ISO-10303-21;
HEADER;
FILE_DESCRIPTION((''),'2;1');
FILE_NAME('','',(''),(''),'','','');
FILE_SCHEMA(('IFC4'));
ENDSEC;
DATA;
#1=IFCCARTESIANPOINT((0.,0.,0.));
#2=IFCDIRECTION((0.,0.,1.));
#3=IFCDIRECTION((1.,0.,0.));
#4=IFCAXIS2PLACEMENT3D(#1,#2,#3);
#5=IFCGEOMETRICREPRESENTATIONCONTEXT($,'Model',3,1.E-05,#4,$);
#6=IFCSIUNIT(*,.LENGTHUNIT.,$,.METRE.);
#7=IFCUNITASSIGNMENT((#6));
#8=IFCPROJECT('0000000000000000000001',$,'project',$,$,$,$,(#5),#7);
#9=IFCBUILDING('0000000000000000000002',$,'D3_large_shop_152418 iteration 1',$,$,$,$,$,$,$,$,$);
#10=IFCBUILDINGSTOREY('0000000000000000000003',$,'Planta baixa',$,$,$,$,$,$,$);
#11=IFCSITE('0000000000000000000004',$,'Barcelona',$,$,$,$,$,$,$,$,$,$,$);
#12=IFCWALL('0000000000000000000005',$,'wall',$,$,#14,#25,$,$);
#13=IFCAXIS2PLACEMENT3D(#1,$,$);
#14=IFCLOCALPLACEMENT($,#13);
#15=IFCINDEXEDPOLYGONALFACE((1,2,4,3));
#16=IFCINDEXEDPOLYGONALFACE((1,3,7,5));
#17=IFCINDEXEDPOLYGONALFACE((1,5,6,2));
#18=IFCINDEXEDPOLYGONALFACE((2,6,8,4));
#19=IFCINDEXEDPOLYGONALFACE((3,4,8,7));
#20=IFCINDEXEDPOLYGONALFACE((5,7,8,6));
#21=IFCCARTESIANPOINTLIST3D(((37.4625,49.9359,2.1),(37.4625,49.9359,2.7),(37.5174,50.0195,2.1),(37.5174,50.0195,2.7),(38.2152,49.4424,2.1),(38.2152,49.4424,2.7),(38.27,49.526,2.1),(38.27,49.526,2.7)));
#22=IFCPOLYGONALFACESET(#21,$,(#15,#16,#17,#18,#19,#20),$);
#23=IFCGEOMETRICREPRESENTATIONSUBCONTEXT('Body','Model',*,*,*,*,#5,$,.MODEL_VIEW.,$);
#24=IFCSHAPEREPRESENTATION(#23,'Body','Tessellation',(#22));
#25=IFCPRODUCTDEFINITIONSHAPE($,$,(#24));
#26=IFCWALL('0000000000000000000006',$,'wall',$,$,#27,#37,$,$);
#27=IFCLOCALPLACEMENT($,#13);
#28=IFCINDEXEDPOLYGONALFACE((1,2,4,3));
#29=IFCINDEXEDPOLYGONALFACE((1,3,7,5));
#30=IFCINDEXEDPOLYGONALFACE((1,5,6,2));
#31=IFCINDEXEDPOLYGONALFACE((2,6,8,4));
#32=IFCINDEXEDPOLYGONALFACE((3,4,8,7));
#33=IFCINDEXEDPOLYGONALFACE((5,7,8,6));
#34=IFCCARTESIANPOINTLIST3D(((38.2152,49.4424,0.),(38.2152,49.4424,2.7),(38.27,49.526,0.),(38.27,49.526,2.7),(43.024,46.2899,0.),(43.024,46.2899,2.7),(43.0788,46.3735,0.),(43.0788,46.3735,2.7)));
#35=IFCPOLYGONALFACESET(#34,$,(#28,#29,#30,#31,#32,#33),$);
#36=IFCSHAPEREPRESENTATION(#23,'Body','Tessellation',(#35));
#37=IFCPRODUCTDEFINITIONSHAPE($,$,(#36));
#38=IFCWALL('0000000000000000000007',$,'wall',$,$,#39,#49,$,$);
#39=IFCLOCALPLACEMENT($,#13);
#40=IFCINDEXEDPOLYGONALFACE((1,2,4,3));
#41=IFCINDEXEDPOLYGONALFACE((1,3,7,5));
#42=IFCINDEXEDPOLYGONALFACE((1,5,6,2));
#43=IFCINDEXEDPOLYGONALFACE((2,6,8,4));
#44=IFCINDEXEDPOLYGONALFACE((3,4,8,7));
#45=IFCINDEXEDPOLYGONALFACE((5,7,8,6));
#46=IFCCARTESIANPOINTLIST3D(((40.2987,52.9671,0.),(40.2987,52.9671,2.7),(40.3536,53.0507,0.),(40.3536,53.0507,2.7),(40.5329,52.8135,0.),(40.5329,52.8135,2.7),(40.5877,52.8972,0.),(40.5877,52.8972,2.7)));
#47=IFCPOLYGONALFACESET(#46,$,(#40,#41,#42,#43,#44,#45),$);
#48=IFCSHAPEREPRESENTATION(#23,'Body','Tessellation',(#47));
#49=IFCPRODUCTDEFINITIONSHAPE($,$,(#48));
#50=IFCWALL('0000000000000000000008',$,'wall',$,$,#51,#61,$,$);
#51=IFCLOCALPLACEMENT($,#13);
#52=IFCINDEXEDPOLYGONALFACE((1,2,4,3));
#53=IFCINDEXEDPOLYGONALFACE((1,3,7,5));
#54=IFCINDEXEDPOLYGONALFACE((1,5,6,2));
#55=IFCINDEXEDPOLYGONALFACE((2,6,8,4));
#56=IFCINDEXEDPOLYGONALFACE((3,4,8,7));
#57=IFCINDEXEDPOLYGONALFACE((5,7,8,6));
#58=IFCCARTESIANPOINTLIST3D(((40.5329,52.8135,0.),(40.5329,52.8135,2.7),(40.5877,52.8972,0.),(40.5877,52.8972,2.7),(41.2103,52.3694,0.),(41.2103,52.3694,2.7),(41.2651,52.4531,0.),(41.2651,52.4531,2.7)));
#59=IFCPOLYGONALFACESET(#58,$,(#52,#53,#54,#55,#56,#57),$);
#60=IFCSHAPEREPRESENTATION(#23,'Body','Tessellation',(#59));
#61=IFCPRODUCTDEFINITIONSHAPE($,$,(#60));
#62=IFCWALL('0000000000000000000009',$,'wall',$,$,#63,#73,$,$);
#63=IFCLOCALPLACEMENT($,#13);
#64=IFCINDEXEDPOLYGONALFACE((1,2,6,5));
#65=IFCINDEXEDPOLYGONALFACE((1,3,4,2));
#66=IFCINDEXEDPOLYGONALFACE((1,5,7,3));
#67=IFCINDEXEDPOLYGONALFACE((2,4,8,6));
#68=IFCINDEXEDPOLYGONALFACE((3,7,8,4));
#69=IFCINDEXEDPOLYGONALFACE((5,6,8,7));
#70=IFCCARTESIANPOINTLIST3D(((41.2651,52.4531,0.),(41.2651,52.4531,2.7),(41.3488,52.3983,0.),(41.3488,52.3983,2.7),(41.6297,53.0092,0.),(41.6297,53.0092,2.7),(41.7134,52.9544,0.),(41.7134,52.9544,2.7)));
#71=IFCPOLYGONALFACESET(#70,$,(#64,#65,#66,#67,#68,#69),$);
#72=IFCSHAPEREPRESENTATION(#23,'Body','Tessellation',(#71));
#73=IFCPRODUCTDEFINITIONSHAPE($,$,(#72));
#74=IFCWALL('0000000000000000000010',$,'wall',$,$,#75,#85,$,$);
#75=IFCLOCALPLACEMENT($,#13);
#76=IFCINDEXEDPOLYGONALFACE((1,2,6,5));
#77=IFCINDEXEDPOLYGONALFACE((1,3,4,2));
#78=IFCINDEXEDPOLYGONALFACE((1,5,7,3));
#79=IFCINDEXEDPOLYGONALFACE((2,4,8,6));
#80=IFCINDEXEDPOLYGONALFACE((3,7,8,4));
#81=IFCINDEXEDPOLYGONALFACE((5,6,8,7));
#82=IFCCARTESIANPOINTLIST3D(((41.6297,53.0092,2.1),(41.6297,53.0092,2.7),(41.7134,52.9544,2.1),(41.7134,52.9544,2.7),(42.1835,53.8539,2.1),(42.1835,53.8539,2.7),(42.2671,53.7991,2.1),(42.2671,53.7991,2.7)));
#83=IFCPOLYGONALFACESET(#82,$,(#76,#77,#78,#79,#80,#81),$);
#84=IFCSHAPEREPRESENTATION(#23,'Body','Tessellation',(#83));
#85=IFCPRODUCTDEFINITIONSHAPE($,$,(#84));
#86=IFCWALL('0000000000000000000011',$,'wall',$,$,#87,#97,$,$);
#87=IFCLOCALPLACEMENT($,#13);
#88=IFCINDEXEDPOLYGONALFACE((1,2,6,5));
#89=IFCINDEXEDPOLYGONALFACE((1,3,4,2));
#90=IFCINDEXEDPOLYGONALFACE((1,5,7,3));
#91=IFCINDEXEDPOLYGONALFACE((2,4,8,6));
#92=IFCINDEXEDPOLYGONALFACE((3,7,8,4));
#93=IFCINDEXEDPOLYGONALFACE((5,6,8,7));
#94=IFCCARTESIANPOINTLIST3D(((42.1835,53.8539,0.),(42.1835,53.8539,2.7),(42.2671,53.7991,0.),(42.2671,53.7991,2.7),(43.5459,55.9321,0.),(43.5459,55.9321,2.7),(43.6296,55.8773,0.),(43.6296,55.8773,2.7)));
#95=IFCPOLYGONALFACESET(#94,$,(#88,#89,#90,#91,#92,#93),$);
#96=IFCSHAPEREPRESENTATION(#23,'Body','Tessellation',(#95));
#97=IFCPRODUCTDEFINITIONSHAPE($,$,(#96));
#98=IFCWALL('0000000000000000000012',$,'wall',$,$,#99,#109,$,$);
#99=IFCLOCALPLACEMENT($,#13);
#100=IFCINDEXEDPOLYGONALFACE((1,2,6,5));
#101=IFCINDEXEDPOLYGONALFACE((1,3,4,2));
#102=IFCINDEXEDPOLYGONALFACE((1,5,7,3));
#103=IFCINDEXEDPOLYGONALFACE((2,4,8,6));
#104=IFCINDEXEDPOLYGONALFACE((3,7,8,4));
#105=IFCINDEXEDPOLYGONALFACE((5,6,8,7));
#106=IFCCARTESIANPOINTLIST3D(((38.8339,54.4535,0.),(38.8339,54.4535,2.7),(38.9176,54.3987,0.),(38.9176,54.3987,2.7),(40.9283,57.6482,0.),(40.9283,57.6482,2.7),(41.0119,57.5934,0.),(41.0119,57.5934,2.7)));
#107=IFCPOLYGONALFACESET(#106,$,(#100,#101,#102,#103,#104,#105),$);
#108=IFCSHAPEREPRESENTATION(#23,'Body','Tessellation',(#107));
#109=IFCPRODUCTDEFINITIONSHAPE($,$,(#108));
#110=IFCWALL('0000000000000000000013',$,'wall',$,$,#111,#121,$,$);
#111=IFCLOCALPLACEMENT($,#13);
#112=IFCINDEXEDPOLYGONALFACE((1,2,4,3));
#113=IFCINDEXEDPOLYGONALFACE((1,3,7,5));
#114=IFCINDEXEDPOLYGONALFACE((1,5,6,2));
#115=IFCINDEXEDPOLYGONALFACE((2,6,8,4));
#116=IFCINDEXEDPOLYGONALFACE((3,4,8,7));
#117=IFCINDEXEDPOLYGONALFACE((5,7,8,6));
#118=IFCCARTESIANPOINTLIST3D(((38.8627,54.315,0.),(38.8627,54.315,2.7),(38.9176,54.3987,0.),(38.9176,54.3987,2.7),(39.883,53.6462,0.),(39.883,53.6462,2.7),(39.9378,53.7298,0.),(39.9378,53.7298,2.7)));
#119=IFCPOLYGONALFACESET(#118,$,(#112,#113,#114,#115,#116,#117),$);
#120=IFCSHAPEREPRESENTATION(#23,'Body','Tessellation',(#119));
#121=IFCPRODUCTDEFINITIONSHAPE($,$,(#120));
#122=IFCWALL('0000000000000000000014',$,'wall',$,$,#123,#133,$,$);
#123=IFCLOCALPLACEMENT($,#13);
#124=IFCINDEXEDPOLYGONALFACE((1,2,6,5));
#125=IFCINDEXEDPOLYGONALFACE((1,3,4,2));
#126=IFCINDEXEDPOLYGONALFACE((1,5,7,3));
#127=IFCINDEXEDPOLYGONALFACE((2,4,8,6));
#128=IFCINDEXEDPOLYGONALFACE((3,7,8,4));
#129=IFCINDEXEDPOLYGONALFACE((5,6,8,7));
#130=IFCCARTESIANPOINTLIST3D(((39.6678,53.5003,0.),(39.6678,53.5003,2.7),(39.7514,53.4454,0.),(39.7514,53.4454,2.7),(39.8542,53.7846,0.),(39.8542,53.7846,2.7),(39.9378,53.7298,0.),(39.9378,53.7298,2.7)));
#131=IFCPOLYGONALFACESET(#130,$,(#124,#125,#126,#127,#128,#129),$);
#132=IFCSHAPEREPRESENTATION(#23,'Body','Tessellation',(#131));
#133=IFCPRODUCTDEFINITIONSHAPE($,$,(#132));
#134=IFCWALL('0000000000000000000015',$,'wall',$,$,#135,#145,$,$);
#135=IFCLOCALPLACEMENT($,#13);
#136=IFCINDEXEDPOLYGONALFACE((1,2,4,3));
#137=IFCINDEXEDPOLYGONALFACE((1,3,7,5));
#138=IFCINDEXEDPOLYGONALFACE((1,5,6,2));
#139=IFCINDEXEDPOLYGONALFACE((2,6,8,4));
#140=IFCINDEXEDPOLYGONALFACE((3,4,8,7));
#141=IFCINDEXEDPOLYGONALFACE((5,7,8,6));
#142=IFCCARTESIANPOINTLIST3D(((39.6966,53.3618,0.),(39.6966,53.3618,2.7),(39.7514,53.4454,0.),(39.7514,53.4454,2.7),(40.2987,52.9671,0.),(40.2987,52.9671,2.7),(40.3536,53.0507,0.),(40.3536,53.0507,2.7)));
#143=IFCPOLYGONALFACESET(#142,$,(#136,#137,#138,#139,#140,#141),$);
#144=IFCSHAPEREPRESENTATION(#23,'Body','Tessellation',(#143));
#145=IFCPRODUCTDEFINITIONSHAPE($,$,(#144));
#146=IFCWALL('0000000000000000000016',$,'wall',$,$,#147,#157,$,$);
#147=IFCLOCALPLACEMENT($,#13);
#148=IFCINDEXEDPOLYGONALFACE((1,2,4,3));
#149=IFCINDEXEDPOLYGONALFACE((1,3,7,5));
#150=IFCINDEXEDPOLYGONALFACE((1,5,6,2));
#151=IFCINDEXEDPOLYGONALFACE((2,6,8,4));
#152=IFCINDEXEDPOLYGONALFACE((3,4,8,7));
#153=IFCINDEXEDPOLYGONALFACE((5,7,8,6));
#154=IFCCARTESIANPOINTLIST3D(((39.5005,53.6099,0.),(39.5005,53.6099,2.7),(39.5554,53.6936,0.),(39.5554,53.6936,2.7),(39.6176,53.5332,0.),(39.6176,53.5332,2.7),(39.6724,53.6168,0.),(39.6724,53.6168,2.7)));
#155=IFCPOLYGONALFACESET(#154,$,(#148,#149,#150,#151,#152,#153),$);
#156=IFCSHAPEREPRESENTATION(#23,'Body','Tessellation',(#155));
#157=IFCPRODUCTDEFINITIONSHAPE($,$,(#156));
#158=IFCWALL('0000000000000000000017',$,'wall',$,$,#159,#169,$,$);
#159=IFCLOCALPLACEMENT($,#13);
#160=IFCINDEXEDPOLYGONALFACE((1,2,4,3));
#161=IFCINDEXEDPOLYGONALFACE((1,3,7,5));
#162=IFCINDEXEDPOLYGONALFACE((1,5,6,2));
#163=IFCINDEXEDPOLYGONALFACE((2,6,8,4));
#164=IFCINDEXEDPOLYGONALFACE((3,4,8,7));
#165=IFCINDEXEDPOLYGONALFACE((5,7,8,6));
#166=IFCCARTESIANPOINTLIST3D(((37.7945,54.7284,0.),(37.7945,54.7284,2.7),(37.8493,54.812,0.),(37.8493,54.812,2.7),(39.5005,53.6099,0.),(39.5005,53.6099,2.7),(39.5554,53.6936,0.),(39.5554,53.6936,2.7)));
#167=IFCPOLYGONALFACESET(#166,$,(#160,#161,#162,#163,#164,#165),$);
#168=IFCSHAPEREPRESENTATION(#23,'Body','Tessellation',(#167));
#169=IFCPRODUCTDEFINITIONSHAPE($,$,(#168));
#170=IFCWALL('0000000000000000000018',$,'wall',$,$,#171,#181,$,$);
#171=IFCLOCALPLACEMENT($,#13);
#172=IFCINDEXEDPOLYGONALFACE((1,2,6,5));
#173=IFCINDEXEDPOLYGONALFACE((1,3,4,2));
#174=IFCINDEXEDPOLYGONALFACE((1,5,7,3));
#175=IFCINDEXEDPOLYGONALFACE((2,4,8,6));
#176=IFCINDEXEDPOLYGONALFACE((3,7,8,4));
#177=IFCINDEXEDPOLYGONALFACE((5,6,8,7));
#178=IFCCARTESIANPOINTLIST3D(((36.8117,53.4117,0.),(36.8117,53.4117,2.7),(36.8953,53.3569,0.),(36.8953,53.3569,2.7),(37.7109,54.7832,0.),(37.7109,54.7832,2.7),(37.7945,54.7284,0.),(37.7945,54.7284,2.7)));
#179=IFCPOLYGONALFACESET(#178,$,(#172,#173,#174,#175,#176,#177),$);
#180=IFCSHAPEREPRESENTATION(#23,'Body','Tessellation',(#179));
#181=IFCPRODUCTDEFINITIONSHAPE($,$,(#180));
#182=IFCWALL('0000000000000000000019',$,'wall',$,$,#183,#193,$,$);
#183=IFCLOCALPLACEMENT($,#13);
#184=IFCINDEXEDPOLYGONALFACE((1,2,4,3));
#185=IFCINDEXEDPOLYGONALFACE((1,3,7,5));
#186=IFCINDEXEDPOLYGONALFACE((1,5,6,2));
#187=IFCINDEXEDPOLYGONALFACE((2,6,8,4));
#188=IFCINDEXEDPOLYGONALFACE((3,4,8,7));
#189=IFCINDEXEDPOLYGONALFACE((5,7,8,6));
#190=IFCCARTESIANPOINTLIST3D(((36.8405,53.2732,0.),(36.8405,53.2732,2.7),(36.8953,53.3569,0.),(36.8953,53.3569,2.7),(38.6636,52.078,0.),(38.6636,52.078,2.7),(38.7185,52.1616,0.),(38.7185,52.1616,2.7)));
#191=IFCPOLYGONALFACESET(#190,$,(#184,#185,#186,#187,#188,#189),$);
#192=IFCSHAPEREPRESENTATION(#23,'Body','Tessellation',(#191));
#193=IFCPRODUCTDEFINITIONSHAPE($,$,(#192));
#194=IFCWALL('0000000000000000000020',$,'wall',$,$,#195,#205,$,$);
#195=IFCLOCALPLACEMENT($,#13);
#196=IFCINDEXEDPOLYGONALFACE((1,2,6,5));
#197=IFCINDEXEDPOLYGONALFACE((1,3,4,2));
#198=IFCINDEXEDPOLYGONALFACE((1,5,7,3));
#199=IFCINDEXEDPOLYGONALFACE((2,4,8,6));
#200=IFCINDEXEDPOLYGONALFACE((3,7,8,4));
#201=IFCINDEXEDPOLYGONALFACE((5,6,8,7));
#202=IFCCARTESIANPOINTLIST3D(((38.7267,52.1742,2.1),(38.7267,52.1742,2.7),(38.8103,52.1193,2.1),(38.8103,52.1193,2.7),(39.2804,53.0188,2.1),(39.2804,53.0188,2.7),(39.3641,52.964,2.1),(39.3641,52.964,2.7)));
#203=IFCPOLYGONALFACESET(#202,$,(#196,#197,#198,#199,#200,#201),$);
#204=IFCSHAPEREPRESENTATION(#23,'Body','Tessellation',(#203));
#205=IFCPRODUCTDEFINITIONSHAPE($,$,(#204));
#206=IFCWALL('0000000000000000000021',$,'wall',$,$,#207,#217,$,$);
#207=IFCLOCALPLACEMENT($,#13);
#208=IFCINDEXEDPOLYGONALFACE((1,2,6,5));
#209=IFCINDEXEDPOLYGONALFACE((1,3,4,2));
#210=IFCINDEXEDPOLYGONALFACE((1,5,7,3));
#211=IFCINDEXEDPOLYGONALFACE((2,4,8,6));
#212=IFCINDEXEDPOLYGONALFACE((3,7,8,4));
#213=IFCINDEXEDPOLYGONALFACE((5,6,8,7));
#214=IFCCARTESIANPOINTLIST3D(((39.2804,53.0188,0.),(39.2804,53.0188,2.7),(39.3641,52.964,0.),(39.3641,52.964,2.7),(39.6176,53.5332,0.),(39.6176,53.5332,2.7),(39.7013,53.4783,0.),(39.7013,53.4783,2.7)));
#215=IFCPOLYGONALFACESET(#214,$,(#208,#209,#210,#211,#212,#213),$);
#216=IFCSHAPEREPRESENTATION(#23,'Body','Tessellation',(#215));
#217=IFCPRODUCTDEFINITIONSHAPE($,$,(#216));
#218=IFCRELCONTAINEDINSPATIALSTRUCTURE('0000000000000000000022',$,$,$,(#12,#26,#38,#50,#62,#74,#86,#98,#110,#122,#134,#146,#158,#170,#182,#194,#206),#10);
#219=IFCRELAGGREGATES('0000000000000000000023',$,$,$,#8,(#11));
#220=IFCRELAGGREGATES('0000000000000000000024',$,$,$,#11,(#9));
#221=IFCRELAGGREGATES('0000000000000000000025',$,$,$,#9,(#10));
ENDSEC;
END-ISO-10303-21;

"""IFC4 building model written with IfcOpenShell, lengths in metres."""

from ifc_helpers import new_model, si_unit, frame, origin, origin_with_axes, place, context, subcontext, project, spatial, polyline, outline, extrude, element, save


model = new_model("IFC4")

# Units and contexts
model_context = context("Model", 3, precision=1e-05, world=origin_with_axes())
body_context = subcontext(model_context, "Body", "Model", "MODEL_VIEW")
ifc_project = project(units=[si_unit("LENGTHUNIT", "METRE")], contexts=[model_context])

# Site, building, storey
site = spatial("IfcSite", under=ifc_project, Name="Barcelona")
building = spatial("IfcBuilding", under=site, Name="D3_large_shop_152418 iteration 1")
storey = spatial("IfcBuildingStorey", under=building, Name="Planta baixa")

# Walls
wall_1_placement = place(None, origin_with_axes())
element("IfcWall", 1, at=wall_1_placement, inside=storey, Name="wall", context=body_context, shape_type="SweptSolid", body=[
    extrude(outline(polyline([(37.5174, 50.0195), (38.27, 49.526), (38.2152, 49.4424), (37.4625, 49.9359), (37.5174, 50.0195)])), frame((0.0, 0.0, 2.1)), (0.0, 0.0, 1.0), 0.6),
])
wall_2_placement = place(None, origin_with_axes())
element("IfcWall", 2, at=wall_2_placement, inside=storey, Name="wall", context=body_context, shape_type="SweptSolid", body=[
    extrude(outline(polyline([(38.27, 49.526), (43.0788, 46.3735), (43.024, 46.2899), (38.2152, 49.4424), (38.27, 49.526)])), origin(), (0.0, 0.0, 1.0), 2.7),
])
wall_3_placement = place(None, origin_with_axes())
element("IfcWall", 3, at=wall_3_placement, inside=storey, Name="wall", context=body_context, shape_type="SweptSolid", body=[
    extrude(outline(polyline([(40.3536, 53.0507), (40.5877, 52.8972), (40.5329, 52.8135), (40.2987, 52.9671), (40.3536, 53.0507)])), origin(), (0.0, 0.0, 1.0), 2.7),
])
wall_4_placement = place(None, origin_with_axes())
element("IfcWall", 4, at=wall_4_placement, inside=storey, Name="wall", context=body_context, shape_type="SweptSolid", body=[
    extrude(outline(polyline([(40.5877, 52.8972), (41.2651, 52.4531), (41.2103, 52.3694), (40.5329, 52.8135), (40.5877, 52.8972)])), origin(), (0.0, 0.0, 1.0), 2.7),
])
wall_5_placement = place(None, origin_with_axes())
element("IfcWall", 5, at=wall_5_placement, inside=storey, Name="wall", context=body_context, shape_type="SweptSolid", body=[
    extrude(outline(polyline([(41.2651, 52.4531), (41.6297, 53.0092), (41.7134, 52.9544), (41.3488, 52.3983), (41.2651, 52.4531)])), origin(), (0.0, 0.0, 1.0), 2.7),
])
wall_6_placement = place(None, origin_with_axes())
element("IfcWall", 6, at=wall_6_placement, inside=storey, Name="wall", context=body_context, shape_type="SweptSolid", body=[
    extrude(outline(polyline([(41.6297, 53.0092), (42.1835, 53.8539), (42.2671, 53.7991), (41.7134, 52.9544), (41.6297, 53.0092)])), frame((0.0, 0.0, 2.1)), (0.0, 0.0, 1.0), 0.6),
])
wall_7_placement = place(None, origin_with_axes())
element("IfcWall", 7, at=wall_7_placement, inside=storey, Name="wall", context=body_context, shape_type="SweptSolid", body=[
    extrude(outline(polyline([(42.1835, 53.8539), (43.5459, 55.9321), (43.6296, 55.8773), (42.2671, 53.7991), (42.1835, 53.8539)])), origin(), (0.0, 0.0, 1.0), 2.7),
])
wall_8_placement = place(None, origin_with_axes())
element("IfcWall", 8, at=wall_8_placement, inside=storey, Name="wall", context=body_context, shape_type="SweptSolid", body=[
    extrude(outline(polyline([(41.0119, 57.5934), (38.9176, 54.3987), (38.8339, 54.4535), (40.9283, 57.6482), (41.0119, 57.5934)])), origin(), (0.0, 0.0, 1.0), 2.7),
])
wall_9_placement = place(None, origin_with_axes())
element("IfcWall", 9, at=wall_9_placement, inside=storey, Name="wall", context=body_context, shape_type="SweptSolid", body=[
    extrude(outline(polyline([(38.9176, 54.3987), (39.9378, 53.7298), (39.883, 53.6462), (38.8627, 54.315), (38.9176, 54.3987)])), origin(), (0.0, 0.0, 1.0), 2.7),
])
wall_10_placement = place(None, origin_with_axes())
element("IfcWall", 10, at=wall_10_placement, inside=storey, Name="wall", context=body_context, shape_type="SweptSolid", body=[
    extrude(outline(polyline([(39.9378, 53.7298), (39.7514, 53.4454), (39.6678, 53.5003), (39.8542, 53.7846), (39.9378, 53.7298)])), origin(), (0.0, 0.0, 1.0), 2.7),
])
wall_11_placement = place(None, origin_with_axes())
element("IfcWall", 11, at=wall_11_placement, inside=storey, Name="wall", context=body_context, shape_type="SweptSolid", body=[
    extrude(outline(polyline([(39.7514, 53.4454), (40.3536, 53.0507), (40.2987, 52.9671), (39.6966, 53.3618), (39.7514, 53.4454)])), origin(), (0.0, 0.0, 1.0), 2.7),
])
wall_12_placement = place(None, origin_with_axes())
element("IfcWall", 12, at=wall_12_placement, inside=storey, Name="wall", context=body_context, shape_type="SweptSolid", body=[
    extrude(outline(polyline([(39.6176, 53.5332), (39.5005, 53.6099), (39.5554, 53.6936), (39.6724, 53.6168), (39.6176, 53.5332)])), origin(), (0.0, 0.0, 1.0), 2.7),
])
wall_13_placement = place(None, origin_with_axes())
element("IfcWall", 13, at=wall_13_placement, inside=storey, Name="wall", context=body_context, shape_type="SweptSolid", body=[
    extrude(outline(polyline([(39.5005, 53.6099), (37.7945, 54.7284), (37.8493, 54.812), (39.5554, 53.6936), (39.5005, 53.6099)])), origin(), (0.0, 0.0, 1.0), 2.7),
])
wall_14_placement = place(None, origin_with_axes())
element("IfcWall", 14, at=wall_14_placement, inside=storey, Name="wall", context=body_context, shape_type="SweptSolid", body=[
    extrude(outline(polyline([(37.7945, 54.7284), (36.8953, 53.3569), (36.8117, 53.4117), (37.7109, 54.7832), (37.7945, 54.7284)])), origin(), (0.0, 0.0, 1.0), 2.7),
])
wall_15_placement = place(None, origin_with_axes())
element("IfcWall", 15, at=wall_15_placement, inside=storey, Name="wall", context=body_context, shape_type="SweptSolid", body=[
    extrude(outline(polyline([(36.8953, 53.3569), (38.7185, 52.1616), (38.6636, 52.078), (36.8405, 53.2732), (36.8953, 53.3569)])), origin(), (0.0, 0.0, 1.0), 2.7),
])
wall_16_placement = place(None, origin_with_axes())
element("IfcWall", 16, at=wall_16_placement, inside=storey, Name="wall", context=body_context, shape_type="SweptSolid", body=[
    extrude(outline(polyline([(38.7267, 52.1742), (39.2804, 53.0188), (39.3641, 52.964), (38.8103, 52.1193), (38.7267, 52.1742)])), frame((0.0, 0.0, 2.1)), (0.0, 0.0, 1.0), 0.6),
])
wall_17_placement = place(None, origin_with_axes())
element("IfcWall", 17, at=wall_17_placement, inside=storey, Name="wall", context=body_context, shape_type="SweptSolid", body=[
    extrude(outline(polyline([(39.2804, 53.0188), (39.6176, 53.5332), (39.7013, 53.4783), (39.3641, 52.964), (39.2804, 53.0188)])), origin(), (0.0, 0.0, 1.0), 2.7),
])

save(model, "model.ifc")
